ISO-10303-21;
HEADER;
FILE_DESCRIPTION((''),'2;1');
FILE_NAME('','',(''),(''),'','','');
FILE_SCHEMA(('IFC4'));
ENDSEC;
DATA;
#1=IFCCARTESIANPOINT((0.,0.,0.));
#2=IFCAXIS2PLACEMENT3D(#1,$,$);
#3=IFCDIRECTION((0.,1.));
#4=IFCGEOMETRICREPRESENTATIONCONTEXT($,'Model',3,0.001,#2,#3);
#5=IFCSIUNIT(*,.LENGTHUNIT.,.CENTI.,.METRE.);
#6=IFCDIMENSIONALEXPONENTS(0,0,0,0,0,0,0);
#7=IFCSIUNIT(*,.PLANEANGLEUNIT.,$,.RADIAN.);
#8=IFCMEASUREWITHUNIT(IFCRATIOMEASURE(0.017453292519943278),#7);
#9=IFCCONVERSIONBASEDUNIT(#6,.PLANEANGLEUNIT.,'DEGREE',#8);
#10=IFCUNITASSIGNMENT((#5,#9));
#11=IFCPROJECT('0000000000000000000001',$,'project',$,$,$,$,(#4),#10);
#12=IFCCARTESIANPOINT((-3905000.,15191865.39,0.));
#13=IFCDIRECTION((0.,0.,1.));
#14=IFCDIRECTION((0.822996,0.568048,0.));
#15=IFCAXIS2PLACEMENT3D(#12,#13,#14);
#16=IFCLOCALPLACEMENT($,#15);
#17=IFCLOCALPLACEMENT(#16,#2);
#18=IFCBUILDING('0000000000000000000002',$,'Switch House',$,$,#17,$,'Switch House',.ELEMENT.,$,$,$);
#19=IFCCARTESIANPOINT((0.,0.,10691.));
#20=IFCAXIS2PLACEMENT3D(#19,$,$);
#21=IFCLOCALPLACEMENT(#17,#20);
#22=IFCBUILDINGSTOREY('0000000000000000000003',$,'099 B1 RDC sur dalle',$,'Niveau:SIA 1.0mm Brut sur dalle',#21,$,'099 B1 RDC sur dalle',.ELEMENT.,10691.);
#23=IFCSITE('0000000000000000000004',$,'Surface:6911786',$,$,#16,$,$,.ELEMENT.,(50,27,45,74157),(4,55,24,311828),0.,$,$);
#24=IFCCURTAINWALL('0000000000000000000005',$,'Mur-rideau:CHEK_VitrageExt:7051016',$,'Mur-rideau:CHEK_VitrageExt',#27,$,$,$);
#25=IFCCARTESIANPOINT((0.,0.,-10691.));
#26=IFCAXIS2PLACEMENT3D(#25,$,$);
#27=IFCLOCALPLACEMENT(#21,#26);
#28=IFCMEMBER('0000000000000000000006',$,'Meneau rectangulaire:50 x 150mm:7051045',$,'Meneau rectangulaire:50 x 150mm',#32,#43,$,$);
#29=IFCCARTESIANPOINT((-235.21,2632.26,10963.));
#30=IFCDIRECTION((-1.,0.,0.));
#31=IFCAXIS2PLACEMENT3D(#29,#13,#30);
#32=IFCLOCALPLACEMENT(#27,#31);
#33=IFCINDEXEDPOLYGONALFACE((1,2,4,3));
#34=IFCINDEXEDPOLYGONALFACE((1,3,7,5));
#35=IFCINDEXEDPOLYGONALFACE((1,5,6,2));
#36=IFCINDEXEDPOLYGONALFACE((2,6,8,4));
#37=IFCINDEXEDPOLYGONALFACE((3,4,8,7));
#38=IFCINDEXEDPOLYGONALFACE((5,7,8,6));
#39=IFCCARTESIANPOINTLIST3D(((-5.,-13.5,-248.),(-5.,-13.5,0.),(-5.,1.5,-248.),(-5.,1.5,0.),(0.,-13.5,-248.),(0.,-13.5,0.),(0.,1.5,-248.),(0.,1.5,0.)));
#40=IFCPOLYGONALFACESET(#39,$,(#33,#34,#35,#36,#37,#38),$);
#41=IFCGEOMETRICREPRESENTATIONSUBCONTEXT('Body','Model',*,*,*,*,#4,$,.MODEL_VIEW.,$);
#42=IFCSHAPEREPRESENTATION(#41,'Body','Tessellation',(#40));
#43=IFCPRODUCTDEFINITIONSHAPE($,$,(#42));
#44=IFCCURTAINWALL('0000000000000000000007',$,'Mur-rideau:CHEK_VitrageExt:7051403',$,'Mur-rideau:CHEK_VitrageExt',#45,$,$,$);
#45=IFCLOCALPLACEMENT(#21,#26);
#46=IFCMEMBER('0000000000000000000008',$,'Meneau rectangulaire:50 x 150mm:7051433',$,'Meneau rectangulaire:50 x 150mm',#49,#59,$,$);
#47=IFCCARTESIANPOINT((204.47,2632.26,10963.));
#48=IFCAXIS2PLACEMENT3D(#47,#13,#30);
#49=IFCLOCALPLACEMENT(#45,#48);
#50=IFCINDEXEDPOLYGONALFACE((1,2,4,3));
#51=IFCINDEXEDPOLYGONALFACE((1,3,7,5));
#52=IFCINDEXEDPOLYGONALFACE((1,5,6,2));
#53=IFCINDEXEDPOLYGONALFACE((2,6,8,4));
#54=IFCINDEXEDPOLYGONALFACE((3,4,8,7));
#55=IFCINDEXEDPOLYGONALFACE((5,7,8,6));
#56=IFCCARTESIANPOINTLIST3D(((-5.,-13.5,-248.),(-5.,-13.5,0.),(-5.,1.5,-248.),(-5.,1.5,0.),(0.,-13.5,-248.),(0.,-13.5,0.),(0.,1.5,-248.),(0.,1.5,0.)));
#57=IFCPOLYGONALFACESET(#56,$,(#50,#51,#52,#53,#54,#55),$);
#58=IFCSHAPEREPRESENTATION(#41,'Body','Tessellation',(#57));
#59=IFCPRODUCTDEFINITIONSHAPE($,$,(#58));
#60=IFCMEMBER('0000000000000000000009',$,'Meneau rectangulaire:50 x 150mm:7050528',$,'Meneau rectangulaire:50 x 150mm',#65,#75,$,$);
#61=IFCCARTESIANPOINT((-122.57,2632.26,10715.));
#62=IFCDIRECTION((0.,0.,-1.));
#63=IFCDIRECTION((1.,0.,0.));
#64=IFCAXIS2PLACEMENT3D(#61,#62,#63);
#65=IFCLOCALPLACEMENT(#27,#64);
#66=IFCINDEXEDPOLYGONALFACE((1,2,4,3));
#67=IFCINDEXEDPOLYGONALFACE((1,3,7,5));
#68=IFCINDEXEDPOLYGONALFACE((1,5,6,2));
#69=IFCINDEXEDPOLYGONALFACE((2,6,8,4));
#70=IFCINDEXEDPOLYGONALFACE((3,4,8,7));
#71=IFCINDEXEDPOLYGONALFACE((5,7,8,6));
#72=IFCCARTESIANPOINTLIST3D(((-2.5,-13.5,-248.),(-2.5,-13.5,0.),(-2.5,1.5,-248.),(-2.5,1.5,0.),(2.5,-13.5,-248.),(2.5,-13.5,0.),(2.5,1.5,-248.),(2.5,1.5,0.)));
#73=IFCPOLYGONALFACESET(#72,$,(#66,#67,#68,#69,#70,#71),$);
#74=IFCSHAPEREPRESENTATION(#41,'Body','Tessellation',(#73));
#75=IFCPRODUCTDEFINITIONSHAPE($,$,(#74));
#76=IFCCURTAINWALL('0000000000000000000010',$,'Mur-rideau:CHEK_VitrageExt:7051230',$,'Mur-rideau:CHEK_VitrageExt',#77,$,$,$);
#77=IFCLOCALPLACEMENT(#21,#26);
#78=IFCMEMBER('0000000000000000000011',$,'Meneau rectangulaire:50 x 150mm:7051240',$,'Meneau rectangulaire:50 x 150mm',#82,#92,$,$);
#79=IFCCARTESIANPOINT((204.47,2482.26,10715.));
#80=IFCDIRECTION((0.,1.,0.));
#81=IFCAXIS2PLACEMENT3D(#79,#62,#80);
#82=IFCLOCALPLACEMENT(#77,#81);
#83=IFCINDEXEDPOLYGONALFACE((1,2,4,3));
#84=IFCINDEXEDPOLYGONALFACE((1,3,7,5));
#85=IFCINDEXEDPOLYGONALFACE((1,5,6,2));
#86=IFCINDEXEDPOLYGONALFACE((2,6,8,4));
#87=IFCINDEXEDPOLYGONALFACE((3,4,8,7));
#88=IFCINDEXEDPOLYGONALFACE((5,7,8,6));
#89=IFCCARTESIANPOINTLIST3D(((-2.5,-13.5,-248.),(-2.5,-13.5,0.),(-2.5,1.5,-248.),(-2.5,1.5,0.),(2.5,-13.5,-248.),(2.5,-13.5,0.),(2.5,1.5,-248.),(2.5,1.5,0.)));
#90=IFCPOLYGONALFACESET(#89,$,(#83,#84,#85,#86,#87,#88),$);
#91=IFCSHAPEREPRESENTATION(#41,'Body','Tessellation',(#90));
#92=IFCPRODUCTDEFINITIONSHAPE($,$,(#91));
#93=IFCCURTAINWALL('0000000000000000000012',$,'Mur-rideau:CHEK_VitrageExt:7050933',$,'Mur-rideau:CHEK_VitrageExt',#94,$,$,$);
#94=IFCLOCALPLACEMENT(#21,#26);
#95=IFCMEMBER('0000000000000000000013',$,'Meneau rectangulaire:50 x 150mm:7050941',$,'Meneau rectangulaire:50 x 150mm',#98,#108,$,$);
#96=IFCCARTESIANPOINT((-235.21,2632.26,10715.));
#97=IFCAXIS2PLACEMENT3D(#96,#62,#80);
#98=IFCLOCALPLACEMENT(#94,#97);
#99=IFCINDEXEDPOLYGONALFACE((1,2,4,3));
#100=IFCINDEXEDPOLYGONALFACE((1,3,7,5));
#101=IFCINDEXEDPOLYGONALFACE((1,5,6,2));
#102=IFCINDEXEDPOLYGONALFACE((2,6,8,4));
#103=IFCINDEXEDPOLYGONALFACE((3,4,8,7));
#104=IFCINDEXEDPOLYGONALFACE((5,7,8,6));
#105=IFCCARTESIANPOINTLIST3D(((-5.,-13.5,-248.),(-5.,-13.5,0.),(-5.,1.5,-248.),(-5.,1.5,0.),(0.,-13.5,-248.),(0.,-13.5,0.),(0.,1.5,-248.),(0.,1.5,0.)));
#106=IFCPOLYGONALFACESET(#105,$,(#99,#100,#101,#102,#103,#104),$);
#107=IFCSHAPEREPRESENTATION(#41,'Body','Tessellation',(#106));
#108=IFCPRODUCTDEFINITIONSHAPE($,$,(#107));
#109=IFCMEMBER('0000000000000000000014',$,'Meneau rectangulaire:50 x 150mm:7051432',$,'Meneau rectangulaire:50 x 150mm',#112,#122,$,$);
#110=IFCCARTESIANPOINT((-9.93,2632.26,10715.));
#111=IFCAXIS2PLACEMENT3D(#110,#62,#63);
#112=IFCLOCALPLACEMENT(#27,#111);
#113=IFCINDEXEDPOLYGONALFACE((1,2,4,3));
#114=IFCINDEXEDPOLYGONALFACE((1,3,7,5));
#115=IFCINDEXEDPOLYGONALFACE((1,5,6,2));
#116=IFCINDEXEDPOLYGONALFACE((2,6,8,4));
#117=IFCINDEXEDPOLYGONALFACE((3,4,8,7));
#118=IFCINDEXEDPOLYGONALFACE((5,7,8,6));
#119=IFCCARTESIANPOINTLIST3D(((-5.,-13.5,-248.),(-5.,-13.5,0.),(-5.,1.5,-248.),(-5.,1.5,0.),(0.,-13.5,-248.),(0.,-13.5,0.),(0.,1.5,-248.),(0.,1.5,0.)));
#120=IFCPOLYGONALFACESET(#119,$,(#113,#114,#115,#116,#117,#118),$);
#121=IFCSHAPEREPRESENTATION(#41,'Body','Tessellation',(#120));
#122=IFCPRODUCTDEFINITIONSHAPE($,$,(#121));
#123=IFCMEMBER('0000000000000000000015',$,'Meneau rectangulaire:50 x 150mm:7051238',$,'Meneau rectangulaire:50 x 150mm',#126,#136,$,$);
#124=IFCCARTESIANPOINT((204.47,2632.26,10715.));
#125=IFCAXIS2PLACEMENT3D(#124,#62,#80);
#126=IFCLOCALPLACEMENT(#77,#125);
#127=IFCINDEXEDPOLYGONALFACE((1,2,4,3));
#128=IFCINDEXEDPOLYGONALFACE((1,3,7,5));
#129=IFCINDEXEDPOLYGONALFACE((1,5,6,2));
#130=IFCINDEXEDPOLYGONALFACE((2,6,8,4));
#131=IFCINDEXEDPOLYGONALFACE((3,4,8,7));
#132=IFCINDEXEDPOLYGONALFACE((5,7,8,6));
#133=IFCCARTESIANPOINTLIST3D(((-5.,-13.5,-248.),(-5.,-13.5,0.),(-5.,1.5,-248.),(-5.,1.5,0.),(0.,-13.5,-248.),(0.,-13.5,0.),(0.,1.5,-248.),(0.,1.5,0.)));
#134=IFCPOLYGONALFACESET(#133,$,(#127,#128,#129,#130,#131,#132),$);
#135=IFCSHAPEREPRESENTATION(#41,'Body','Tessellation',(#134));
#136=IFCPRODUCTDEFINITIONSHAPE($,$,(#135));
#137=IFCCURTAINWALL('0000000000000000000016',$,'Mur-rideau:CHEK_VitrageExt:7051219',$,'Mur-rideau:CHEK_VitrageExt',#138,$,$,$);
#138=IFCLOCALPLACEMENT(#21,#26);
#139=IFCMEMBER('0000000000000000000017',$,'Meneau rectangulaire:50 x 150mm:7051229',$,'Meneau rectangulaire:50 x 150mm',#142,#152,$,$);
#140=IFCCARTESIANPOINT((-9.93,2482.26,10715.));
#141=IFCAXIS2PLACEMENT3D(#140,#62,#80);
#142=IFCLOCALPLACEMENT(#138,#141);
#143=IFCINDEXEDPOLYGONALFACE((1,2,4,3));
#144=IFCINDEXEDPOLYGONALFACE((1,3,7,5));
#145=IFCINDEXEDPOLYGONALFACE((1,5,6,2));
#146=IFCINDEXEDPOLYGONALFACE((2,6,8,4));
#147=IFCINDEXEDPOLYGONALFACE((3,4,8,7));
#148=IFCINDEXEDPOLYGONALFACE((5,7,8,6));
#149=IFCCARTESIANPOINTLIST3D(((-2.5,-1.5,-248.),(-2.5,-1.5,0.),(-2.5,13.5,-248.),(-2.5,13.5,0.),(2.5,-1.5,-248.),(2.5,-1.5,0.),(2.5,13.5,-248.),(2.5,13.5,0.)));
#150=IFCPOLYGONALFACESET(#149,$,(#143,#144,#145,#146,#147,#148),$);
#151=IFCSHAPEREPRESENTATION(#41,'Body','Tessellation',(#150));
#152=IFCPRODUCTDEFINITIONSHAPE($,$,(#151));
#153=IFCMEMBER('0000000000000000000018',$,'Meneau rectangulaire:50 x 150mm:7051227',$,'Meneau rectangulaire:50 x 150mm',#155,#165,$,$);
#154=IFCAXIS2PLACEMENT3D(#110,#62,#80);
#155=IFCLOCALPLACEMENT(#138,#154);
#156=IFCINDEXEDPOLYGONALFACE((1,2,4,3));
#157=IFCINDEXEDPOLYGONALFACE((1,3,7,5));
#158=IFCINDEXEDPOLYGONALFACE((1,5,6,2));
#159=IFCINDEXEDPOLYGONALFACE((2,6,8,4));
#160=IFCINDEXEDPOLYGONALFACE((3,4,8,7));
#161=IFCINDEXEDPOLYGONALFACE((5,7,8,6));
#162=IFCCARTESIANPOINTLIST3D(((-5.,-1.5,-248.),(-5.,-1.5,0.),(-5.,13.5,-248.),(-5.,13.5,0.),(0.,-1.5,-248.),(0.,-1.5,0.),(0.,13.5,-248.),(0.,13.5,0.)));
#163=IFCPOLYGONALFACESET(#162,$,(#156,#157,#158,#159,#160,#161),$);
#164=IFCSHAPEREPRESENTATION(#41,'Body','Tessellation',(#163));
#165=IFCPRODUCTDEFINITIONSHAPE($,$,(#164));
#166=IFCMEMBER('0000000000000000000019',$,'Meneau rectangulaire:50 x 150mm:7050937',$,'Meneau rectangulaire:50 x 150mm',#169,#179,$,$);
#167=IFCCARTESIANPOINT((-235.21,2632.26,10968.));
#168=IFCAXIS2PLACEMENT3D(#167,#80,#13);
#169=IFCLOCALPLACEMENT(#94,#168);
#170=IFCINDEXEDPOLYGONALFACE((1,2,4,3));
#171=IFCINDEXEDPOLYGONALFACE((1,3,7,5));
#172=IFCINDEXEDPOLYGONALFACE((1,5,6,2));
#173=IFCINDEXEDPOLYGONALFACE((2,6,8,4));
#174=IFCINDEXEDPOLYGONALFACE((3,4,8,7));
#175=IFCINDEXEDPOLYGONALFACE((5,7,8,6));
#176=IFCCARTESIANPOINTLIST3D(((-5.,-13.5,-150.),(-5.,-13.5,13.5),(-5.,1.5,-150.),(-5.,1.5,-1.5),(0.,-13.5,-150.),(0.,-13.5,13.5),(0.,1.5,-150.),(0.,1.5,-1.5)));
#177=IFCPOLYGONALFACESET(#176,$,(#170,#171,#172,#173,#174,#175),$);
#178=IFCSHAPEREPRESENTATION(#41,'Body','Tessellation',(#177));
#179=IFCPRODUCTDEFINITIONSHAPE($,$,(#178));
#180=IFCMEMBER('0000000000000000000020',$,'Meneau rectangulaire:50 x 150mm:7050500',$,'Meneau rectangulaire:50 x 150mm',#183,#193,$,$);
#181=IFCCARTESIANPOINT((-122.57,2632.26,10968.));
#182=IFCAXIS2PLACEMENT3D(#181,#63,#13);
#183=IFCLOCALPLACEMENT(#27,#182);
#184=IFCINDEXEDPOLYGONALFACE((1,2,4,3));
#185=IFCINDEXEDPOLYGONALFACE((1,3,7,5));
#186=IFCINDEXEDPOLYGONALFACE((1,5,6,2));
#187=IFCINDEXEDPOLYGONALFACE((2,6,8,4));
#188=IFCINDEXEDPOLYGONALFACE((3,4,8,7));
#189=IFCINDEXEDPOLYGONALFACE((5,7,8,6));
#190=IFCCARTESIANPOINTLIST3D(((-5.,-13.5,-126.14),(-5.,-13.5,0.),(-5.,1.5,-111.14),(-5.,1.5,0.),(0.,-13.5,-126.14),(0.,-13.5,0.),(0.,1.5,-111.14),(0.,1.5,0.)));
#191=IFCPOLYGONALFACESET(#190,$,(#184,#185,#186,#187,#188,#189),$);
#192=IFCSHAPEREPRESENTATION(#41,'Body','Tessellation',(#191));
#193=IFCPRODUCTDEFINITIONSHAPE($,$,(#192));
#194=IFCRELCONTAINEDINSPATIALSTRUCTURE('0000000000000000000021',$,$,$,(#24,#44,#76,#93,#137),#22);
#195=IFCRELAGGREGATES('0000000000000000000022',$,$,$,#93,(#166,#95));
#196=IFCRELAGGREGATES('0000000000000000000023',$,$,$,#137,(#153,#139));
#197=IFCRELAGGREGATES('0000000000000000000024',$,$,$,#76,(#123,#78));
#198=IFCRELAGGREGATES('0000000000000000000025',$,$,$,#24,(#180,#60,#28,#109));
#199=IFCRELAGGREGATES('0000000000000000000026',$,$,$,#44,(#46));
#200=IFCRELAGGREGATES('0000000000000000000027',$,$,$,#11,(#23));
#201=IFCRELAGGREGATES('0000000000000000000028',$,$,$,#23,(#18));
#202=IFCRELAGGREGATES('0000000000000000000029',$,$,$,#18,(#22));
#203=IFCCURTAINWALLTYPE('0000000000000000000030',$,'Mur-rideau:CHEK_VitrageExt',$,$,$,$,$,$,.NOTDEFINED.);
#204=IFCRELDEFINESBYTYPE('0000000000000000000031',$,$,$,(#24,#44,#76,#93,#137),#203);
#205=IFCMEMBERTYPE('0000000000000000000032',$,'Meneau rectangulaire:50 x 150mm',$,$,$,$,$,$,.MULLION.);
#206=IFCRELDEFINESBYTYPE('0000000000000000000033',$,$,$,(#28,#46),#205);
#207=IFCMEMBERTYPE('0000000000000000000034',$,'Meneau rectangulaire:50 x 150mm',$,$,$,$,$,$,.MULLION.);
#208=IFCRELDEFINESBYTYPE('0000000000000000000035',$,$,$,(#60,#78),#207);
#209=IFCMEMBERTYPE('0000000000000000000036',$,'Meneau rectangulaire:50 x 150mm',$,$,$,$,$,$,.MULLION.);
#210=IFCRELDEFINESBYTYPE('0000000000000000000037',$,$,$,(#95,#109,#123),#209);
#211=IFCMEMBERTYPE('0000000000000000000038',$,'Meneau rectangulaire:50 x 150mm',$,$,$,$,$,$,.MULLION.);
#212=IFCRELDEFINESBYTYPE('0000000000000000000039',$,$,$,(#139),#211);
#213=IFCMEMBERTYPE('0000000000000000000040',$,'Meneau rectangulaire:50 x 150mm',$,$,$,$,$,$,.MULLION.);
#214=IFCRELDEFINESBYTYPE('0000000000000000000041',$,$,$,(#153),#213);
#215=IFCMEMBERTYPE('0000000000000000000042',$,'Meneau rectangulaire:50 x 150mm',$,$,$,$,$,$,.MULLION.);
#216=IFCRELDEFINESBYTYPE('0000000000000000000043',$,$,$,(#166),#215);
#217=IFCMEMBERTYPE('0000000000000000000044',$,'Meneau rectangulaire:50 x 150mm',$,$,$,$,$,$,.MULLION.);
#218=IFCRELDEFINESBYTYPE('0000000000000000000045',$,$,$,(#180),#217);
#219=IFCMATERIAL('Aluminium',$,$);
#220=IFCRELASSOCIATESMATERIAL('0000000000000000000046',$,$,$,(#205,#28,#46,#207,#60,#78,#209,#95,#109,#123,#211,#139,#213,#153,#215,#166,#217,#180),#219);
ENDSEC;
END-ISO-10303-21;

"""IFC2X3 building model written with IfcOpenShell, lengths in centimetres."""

from ifc_helpers import new_model, entity, si_unit, converted_unit, direction, frame, origin, origin_2d_with_axis, place, context, subcontext, project, spatial, rectangle, extrude, clip, halfspace, source, transform, mapped, material, type_object, type_shapes, element, aggregate, save


model = new_model("IFC2X3")

# Units and contexts
model_context = context("Model", 3, precision=0.001, world=origin(), true_north=direction((0.0, 1.0)))
body_context = subcontext(model_context, "Body", "Model", "MODEL_VIEW")
ifc_project = project(units=[si_unit("LENGTHUNIT", "METRE", prefix="CENTI"), converted_unit("PLANEANGLEUNIT", "DEGREE", entity("IfcRatioMeasure", 0.017453292519943278), si_unit("PLANEANGLEUNIT", "RADIAN"), dimensions=[0, 0, 0, 0, 0, 0, 0])], contexts=[model_context])

# Site, building, storey
site_placement = place(None, frame((-3905000.0, 15191865.39, 0.0), z_axis=(0.0, 0.0, 1.0), x_axis=(0.822996, 0.568048, 0.0)))
site = spatial("IfcSite", under=ifc_project, at=site_placement, Name="Surface:6911786", CompositionType="ELEMENT", RefLatitude=(50, 27, 45, 74157), RefLongitude=(4, 55, 24, 311828), RefElevation=0.0)
building_placement = place(site_placement, origin())
building = spatial("IfcBuilding", under=site, at=building_placement, Name="Switch House", LongName="Switch House", CompositionType="ELEMENT")
storey_placement = place(building_placement, frame((0.0, 0.0, 10691.0)))
storey = spatial("IfcBuildingStorey", under=building, at=storey_placement, Name="099 B1 RDC sur dalle", ObjectType="Niveau:SIA 1.0mm Brut sur dalle", LongName="099 B1 RDC sur dalle", CompositionType="ELEMENT", Elevation=10691.0)

# Curtain walls, members
curtain_wall_type = type_object("IfcCurtainWallType", Name="Mur-rideau:CHEK_VitrageExt", PredefinedType="NOTDEFINED")
curtain_wall_1_placement = place(storey_placement, frame((0.0, 0.0, -10691.0)))
curtain_wall_1 = element("IfcCurtainWall", 1, at=curtain_wall_1_placement, inside=storey, type_object=curtain_wall_type, Name="Mur-rideau:CHEK_VitrageExt:7051016", ObjectType="Mur-rideau:CHEK_VitrageExt")
ifc_material_1 = material(Name="Aluminium")
member_type_1 = type_object("IfcMemberType", Name="Meneau rectangulaire:50 x 150mm", PredefinedType="MULLION", material=ifc_material_1)
shared_shape_1 = source(origin(), body_context, "Body", "SweptSolid", [
    extrude(rectangle(XDim=15.0, YDim=5.0, at=origin_2d_with_axis()), frame((-2.5, -6.0, -248.0), z_axis=(0.0, 0.0, 1.0), x_axis=(0.0, -1.0, 0.0)), (0.0, 0.0, 1.0), 248.0),
])
type_shapes(member_type_1, [shared_shape_1])
member_1_placement = place(curtain_wall_1_placement, frame((-235.21, 2632.26, 10963.0), z_axis=(0.0, 0.0, 1.0), x_axis=(-1.0, 0.0, 0.0)))
member_1 = element("IfcMember", 2, at=member_1_placement, type_object=member_type_1, material=ifc_material_1, Name="Meneau rectangulaire:50 x 150mm:7051045", ObjectType="Meneau rectangulaire:50 x 150mm", context=body_context, shape_type="MappedRepresentation", body=[
    mapped(shared_shape_1, transform((0.0, 0.0, 0.0), scale=1.0)),
])
curtain_wall_2_placement = place(storey_placement, frame((0.0, 0.0, -10691.0)))
curtain_wall_2 = element("IfcCurtainWall", 3, at=curtain_wall_2_placement, inside=storey, type_object=curtain_wall_type, Name="Mur-rideau:CHEK_VitrageExt:7051403", ObjectType="Mur-rideau:CHEK_VitrageExt")
member_2_placement = place(curtain_wall_2_placement, frame((204.47, 2632.26, 10963.0), z_axis=(0.0, 0.0, 1.0), x_axis=(-1.0, 0.0, 0.0)))
member_2 = element("IfcMember", 4, at=member_2_placement, type_object=member_type_1, material=ifc_material_1, Name="Meneau rectangulaire:50 x 150mm:7051433", ObjectType="Meneau rectangulaire:50 x 150mm", context=body_context, shape_type="MappedRepresentation", body=[
    mapped(shared_shape_1, transform((0.0, 0.0, 0.0), scale=1.0)),
])

# Member
member_type_2 = type_object("IfcMemberType", Name="Meneau rectangulaire:50 x 150mm", PredefinedType="MULLION", material=ifc_material_1)
shared_shape_2 = source(origin(), body_context, "Body", "SweptSolid", [
    extrude(rectangle(XDim=15.0, YDim=5.0, at=origin_2d_with_axis()), frame((0.0, -6.0, -248.0), z_axis=(0.0, 0.0, 1.0), x_axis=(0.0, -1.0, 0.0)), (0.0, 0.0, 1.0), 248.0),
])
type_shapes(member_type_2, [shared_shape_2])
member_3_placement = place(curtain_wall_1_placement, frame((-122.57, 2632.26, 10715.0), z_axis=(0.0, 0.0, -1.0), x_axis=(1.0, 0.0, 0.0)))
member_3 = element("IfcMember", 5, at=member_3_placement, type_object=member_type_2, material=ifc_material_1, Name="Meneau rectangulaire:50 x 150mm:7050528", ObjectType="Meneau rectangulaire:50 x 150mm", context=body_context, shape_type="MappedRepresentation", body=[
    mapped(shared_shape_2, transform((0.0, 0.0, 0.0), scale=1.0)),
])

# Curtain walls, members
curtain_wall_3_placement = place(storey_placement, frame((0.0, 0.0, -10691.0)))
curtain_wall_3 = element("IfcCurtainWall", 6, at=curtain_wall_3_placement, inside=storey, type_object=curtain_wall_type, Name="Mur-rideau:CHEK_VitrageExt:7051230", ObjectType="Mur-rideau:CHEK_VitrageExt")
member_4_placement = place(curtain_wall_3_placement, frame((204.47, 2482.26, 10715.0), z_axis=(0.0, 0.0, -1.0), x_axis=(0.0, 1.0, 0.0)))
member_4 = element("IfcMember", 7, at=member_4_placement, type_object=member_type_2, material=ifc_material_1, Name="Meneau rectangulaire:50 x 150mm:7051240", ObjectType="Meneau rectangulaire:50 x 150mm", context=body_context, shape_type="MappedRepresentation", body=[
    mapped(shared_shape_2, transform((0.0, 0.0, 0.0), scale=1.0)),
])
curtain_wall_4_placement = place(storey_placement, frame((0.0, 0.0, -10691.0)))
curtain_wall_4 = element("IfcCurtainWall", 8, at=curtain_wall_4_placement, inside=storey, type_object=curtain_wall_type, Name="Mur-rideau:CHEK_VitrageExt:7050933", ObjectType="Mur-rideau:CHEK_VitrageExt")
member_type_3 = type_object("IfcMemberType", Name="Meneau rectangulaire:50 x 150mm", PredefinedType="MULLION", material=ifc_material_1)
shared_shape_3 = source(origin(), body_context, "Body", "SweptSolid", [
    extrude(rectangle(XDim=15.0, YDim=5.0, at=origin_2d_with_axis()), frame((-2.5, -6.0, -248.0), z_axis=(0.0, 0.0, 1.0), x_axis=(0.0, -1.0, 0.0)), (0.0, 0.0, 1.0), 248.0),
])
type_shapes(member_type_3, [shared_shape_3])
member_5_placement = place(curtain_wall_4_placement, frame((-235.21, 2632.26, 10715.0), z_axis=(0.0, 0.0, -1.0), x_axis=(0.0, 1.0, 0.0)))
member_5 = element("IfcMember", 9, at=member_5_placement, type_object=member_type_3, material=ifc_material_1, Name="Meneau rectangulaire:50 x 150mm:7050941", ObjectType="Meneau rectangulaire:50 x 150mm", context=body_context, shape_type="MappedRepresentation", body=[
    mapped(shared_shape_3, transform((0.0, 0.0, 0.0), scale=1.0)),
])

# Members
member_6_placement = place(curtain_wall_1_placement, frame((-9.93, 2632.26, 10715.0), z_axis=(0.0, 0.0, -1.0), x_axis=(1.0, 0.0, 0.0)))
member_6 = element("IfcMember", 10, at=member_6_placement, type_object=member_type_3, material=ifc_material_1, Name="Meneau rectangulaire:50 x 150mm:7051432", ObjectType="Meneau rectangulaire:50 x 150mm", context=body_context, shape_type="MappedRepresentation", body=[
    mapped(shared_shape_3, transform((0.0, 0.0, 0.0), scale=1.0)),
])
member_7_placement = place(curtain_wall_3_placement, frame((204.47, 2632.26, 10715.0), z_axis=(0.0, 0.0, -1.0), x_axis=(0.0, 1.0, 0.0)))
member_7 = element("IfcMember", 11, at=member_7_placement, type_object=member_type_3, material=ifc_material_1, Name="Meneau rectangulaire:50 x 150mm:7051238", ObjectType="Meneau rectangulaire:50 x 150mm", context=body_context, shape_type="MappedRepresentation", body=[
    mapped(shared_shape_3, transform((0.0, 0.0, 0.0), scale=1.0)),
])

# Curtain wall, members
curtain_wall_5_placement = place(storey_placement, frame((0.0, 0.0, -10691.0)))
curtain_wall_5 = element("IfcCurtainWall", 12, at=curtain_wall_5_placement, inside=storey, type_object=curtain_wall_type, Name="Mur-rideau:CHEK_VitrageExt:7051219", ObjectType="Mur-rideau:CHEK_VitrageExt")
member_type_4 = type_object("IfcMemberType", Name="Meneau rectangulaire:50 x 150mm", PredefinedType="MULLION", material=ifc_material_1)
shared_shape_4 = source(origin(), body_context, "Body", "SweptSolid", [
    extrude(rectangle(XDim=15.0, YDim=5.0, at=origin_2d_with_axis()), frame((0.0, 6.0, -248.0), z_axis=(0.0, 0.0, 1.0), x_axis=(0.0, -1.0, 0.0)), (0.0, 0.0, 1.0), 248.0),
])
type_shapes(member_type_4, [shared_shape_4])
member_8_placement = place(curtain_wall_5_placement, frame((-9.93, 2482.26, 10715.0), z_axis=(0.0, 0.0, -1.0), x_axis=(0.0, 1.0, 0.0)))
member_8 = element("IfcMember", 13, at=member_8_placement, type_object=member_type_4, material=ifc_material_1, Name="Meneau rectangulaire:50 x 150mm:7051229", ObjectType="Meneau rectangulaire:50 x 150mm", context=body_context, shape_type="MappedRepresentation", body=[
    mapped(shared_shape_4, transform((0.0, 0.0, 0.0), scale=1.0)),
])
member_type_5 = type_object("IfcMemberType", Name="Meneau rectangulaire:50 x 150mm", PredefinedType="MULLION", material=ifc_material_1)
shared_shape_5 = source(origin(), body_context, "Body", "SweptSolid", [
    extrude(rectangle(XDim=15.0, YDim=5.0, at=origin_2d_with_axis()), frame((-2.5, 6.0, -248.0), z_axis=(0.0, 0.0, 1.0), x_axis=(0.0, -1.0, 0.0)), (0.0, 0.0, 1.0), 248.0),
])
type_shapes(member_type_5, [shared_shape_5])
member_9_placement = place(curtain_wall_5_placement, frame((-9.93, 2632.26, 10715.0), z_axis=(0.0, 0.0, -1.0), x_axis=(0.0, 1.0, 0.0)))
member_9 = element("IfcMember", 14, at=member_9_placement, type_object=member_type_5, material=ifc_material_1, Name="Meneau rectangulaire:50 x 150mm:7051227", ObjectType="Meneau rectangulaire:50 x 150mm", context=body_context, shape_type="MappedRepresentation", body=[
    mapped(shared_shape_5, transform((0.0, 0.0, 0.0), scale=1.0)),
])

# Members
member_type_6 = type_object("IfcMemberType", Name="Meneau rectangulaire:50 x 150mm", PredefinedType="MULLION", material=ifc_material_1)
shared_shape_6 = source(origin(), body_context, "Body", "SweptSolid", [
    clip(extrude(rectangle(XDim=15.0, YDim=5.0, at=origin_2d_with_axis()), frame((-2.5, -6.0, -150.0), z_axis=(0.0, 0.0, 1.0), x_axis=(0.0, -1.0, 0.0)), (0.0, 0.0, 1.0), 163.5), halfspace(frame((-30.48, 0.0, 0.0), z_axis=(0.0, 0.707107, 0.707107), x_axis=(0.0, 0.707107, -0.707107)), False)),
])
type_shapes(member_type_6, [shared_shape_6])
member_10_placement = place(curtain_wall_4_placement, frame((-235.21, 2632.26, 10968.0), z_axis=(0.0, 1.0, 0.0), x_axis=(0.0, 0.0, 1.0)))
member_10 = element("IfcMember", 15, at=member_10_placement, type_object=member_type_6, material=ifc_material_1, Name="Meneau rectangulaire:50 x 150mm:7050937", ObjectType="Meneau rectangulaire:50 x 150mm", context=body_context, shape_type="MappedRepresentation", body=[
    mapped(shared_shape_6, transform((0.0, 0.0, 0.0), scale=1.0)),
])
aggregate(curtain_wall_4, [member_10, member_5])
member_type_7 = type_object("IfcMemberType", Name="Meneau rectangulaire:50 x 150mm", PredefinedType="MULLION", material=ifc_material_1)
shared_shape_7 = source(origin(), body_context, "Body", "SweptSolid", [
    clip(extrude(rectangle(XDim=15.0, YDim=5.0, at=origin_2d_with_axis()), frame((-2.5, -6.0, -126.14), z_axis=(0.0, 0.0, 1.0), x_axis=(0.0, -1.0, 0.0)), (0.0, 0.0, 1.0), 126.14), halfspace(frame((-30.48, 0.0, -112.64), z_axis=(0.0, 0.707107, -0.707107), x_axis=(0.0, 0.707107, 0.707107)), False)),
])
type_shapes(member_type_7, [shared_shape_7])
member_11_placement = place(curtain_wall_1_placement, frame((-122.57, 2632.26, 10968.0), z_axis=(1.0, 0.0, 0.0), x_axis=(0.0, 0.0, 1.0)))
member_11 = element("IfcMember", 16, at=member_11_placement, type_object=member_type_7, material=ifc_material_1, Name="Meneau rectangulaire:50 x 150mm:7050500", ObjectType="Meneau rectangulaire:50 x 150mm", context=body_context, shape_type="MappedRepresentation", body=[
    mapped(shared_shape_7, transform((0.0, 0.0, 0.0), scale=1.0)),
])

aggregate(curtain_wall_5, [member_9, member_8])
aggregate(curtain_wall_3, [member_7, member_4])
aggregate(curtain_wall_1, [member_11, member_3, member_1, member_6])
aggregate(curtain_wall_2, [member_2])

save(model, "model.ifc")
